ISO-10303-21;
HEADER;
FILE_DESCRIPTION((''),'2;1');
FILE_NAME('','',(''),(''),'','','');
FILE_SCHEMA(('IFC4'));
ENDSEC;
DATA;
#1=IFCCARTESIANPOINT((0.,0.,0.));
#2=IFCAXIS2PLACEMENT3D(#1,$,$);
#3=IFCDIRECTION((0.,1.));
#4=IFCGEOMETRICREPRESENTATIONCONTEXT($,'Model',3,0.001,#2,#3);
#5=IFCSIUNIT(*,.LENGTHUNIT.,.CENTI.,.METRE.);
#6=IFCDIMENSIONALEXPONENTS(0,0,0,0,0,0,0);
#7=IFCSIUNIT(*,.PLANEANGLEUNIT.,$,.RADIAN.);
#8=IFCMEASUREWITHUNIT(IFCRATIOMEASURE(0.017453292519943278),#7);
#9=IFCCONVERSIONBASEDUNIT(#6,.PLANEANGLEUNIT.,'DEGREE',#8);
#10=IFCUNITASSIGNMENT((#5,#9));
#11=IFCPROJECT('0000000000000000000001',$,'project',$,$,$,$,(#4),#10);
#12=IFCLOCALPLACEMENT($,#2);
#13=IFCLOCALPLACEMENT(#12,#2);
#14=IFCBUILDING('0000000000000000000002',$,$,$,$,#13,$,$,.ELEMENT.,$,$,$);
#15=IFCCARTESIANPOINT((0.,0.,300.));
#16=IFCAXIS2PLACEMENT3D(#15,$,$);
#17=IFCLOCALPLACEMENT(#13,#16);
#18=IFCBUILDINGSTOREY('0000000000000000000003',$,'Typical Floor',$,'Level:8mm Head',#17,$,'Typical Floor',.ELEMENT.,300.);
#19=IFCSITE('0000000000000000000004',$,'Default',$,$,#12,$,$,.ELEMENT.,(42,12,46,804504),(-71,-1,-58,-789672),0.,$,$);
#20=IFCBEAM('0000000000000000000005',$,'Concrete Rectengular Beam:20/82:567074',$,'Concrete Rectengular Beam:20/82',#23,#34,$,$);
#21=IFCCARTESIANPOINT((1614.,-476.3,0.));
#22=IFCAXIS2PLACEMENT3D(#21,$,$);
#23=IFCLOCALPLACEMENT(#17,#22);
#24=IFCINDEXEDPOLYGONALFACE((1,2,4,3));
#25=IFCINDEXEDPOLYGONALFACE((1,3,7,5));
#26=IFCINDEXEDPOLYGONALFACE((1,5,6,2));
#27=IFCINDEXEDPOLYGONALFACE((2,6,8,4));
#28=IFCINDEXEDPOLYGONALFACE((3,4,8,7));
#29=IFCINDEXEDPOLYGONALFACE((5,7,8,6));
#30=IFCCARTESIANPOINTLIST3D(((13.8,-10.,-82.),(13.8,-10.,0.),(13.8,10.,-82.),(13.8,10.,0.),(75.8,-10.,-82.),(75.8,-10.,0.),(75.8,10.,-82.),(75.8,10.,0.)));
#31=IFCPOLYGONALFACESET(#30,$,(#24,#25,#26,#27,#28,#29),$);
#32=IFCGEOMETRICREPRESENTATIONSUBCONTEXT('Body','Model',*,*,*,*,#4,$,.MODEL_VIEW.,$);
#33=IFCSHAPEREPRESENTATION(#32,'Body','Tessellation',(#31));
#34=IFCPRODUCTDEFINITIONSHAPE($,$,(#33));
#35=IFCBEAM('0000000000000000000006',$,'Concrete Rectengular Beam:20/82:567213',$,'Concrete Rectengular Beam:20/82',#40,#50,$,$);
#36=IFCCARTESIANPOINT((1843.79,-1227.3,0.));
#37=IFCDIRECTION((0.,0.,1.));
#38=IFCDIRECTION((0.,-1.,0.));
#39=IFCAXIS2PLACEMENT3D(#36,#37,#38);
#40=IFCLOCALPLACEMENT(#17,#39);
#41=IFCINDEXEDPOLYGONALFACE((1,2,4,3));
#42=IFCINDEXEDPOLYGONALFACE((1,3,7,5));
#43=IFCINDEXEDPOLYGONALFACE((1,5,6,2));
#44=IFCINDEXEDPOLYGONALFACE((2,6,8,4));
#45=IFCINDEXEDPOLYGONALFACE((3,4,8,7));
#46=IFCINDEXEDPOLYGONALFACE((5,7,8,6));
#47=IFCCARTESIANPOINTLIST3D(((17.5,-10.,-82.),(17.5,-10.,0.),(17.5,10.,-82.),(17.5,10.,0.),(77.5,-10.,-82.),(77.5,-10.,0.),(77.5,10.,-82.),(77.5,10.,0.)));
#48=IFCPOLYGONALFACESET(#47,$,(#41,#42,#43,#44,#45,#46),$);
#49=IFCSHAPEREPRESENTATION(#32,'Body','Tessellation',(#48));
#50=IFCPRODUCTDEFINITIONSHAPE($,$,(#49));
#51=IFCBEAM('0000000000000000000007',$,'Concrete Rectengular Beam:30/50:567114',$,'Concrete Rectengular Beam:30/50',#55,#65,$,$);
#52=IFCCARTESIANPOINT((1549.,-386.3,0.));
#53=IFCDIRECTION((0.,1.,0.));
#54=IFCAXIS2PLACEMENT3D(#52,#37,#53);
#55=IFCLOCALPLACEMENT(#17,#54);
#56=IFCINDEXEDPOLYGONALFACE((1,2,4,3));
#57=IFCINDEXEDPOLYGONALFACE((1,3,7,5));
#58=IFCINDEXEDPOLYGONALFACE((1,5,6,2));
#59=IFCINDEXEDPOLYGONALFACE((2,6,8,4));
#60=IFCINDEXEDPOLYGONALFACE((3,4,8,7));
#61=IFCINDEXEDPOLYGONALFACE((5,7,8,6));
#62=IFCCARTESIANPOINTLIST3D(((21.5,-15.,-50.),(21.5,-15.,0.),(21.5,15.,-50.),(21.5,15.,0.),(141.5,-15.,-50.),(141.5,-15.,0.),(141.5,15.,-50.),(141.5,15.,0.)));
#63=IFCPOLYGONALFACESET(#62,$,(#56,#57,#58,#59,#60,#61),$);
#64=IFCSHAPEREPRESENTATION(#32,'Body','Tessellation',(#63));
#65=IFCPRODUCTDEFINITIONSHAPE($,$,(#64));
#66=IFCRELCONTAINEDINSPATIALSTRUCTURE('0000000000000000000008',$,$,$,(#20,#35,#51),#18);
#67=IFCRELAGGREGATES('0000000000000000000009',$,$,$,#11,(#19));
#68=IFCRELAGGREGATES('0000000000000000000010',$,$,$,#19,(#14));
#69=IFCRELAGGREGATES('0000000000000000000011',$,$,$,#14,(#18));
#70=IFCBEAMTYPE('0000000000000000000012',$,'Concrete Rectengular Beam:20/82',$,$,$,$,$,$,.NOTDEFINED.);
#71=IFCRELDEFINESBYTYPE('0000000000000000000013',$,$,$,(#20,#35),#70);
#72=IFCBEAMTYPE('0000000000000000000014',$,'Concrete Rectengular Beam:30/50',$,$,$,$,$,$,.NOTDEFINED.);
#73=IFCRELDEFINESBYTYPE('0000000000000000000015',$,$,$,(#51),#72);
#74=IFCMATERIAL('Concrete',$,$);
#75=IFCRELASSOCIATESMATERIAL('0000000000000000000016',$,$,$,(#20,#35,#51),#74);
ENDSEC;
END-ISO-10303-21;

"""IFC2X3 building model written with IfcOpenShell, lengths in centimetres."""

from ifc_helpers import new_model, entity, si_unit, converted_unit, direction, frame, frame_2d, origin, origin_2d_with_axis, place, context, subcontext, project, spatial, rectangle, extrude, material, type_object, element, save


model = new_model("IFC2X3")

# Units and contexts
model_context = context("Model", 3, precision=0.001, world=origin(), true_north=direction((0.0, 1.0)))
body_context = subcontext(model_context, "Body", "Model", "MODEL_VIEW")
ifc_project = project(units=[si_unit("LENGTHUNIT", "METRE", prefix="CENTI"), converted_unit("PLANEANGLEUNIT", "DEGREE", entity("IfcRatioMeasure", 0.017453292519943278), si_unit("PLANEANGLEUNIT", "RADIAN"), dimensions=[0, 0, 0, 0, 0, 0, 0])], contexts=[model_context])

# Site, building, storey
site_placement = place(None, origin())
site = spatial("IfcSite", under=ifc_project, at=site_placement, Name="Default", CompositionType="ELEMENT", RefLatitude=(42, 12, 46, 804504), RefLongitude=(-71, -1, -58, -789672), RefElevation=0.0)
building_placement = place(site_placement, origin())
building = spatial("IfcBuilding", under=site, at=building_placement, CompositionType="ELEMENT")
storey_placement = place(building_placement, frame((0.0, 0.0, 300.0)))
storey = spatial("IfcBuildingStorey", under=building, at=storey_placement, Name="Typical Floor", ObjectType="Level:8mm Head", LongName="Typical Floor", CompositionType="ELEMENT", Elevation=300.0)

# Beams
ifc_material = material(Name="Concrete")
beam_type_1 = type_object("IfcBeamType", Name="Concrete Rectengular Beam:20/82", PredefinedType="NOTDEFINED")
beam_1_placement = place(storey_placement, frame((1614.0, -476.3, 0.0)))
element("IfcBeam", 1, at=beam_1_placement, inside=storey, type_object=beam_type_1, material=ifc_material, Name="Concrete Rectengular Beam:20/82:567074", ObjectType="Concrete Rectengular Beam:20/82", context=body_context, shape_type="SweptSolid", body=[
    extrude(rectangle(XDim=82.0, YDim=20.0, at=origin_2d_with_axis()), frame((13.8, 0.0, -41.0), z_axis=(1.0, 0.0, 0.0), x_axis=(0.0, 0.0, -1.0)), (0.0, 0.0, 1.0), 62.0),
])
beam_2_placement = place(storey_placement, frame((1843.79, -1227.3, 0.0), z_axis=(0.0, 0.0, 1.0), x_axis=(0.0, -1.0, 0.0)))
element("IfcBeam", 2, at=beam_2_placement, inside=storey, type_object=beam_type_1, material=ifc_material, Name="Concrete Rectengular Beam:20/82:567213", ObjectType="Concrete Rectengular Beam:20/82", context=body_context, shape_type="SweptSolid", body=[
    extrude(rectangle(XDim=82.0, YDim=20.0, at=frame_2d((0.0, 0.0), x_axis=(1.0, 0.0))), frame((17.5, 0.0, -41.0), z_axis=(1.0, 0.0, 0.0), x_axis=(0.0, 0.0, -1.0)), (0.0, 0.0, 1.0), 60.0),
])
beam_type_2 = type_object("IfcBeamType", Name="Concrete Rectengular Beam:30/50", PredefinedType="NOTDEFINED")
beam_3_placement = place(storey_placement, frame((1549.0, -386.3, 0.0), z_axis=(0.0, 0.0, 1.0), x_axis=(0.0, 1.0, 0.0)))
element("IfcBeam", 3, at=beam_3_placement, inside=storey, type_object=beam_type_2, material=ifc_material, Name="Concrete Rectengular Beam:30/50:567114", ObjectType="Concrete Rectengular Beam:30/50", context=body_context, shape_type="SweptSolid", body=[
    extrude(rectangle(XDim=50.0, YDim=30.0, at=frame_2d((0.0, 0.0), x_axis=(1.0, 0.0))), frame((21.5, 0.0, -25.0), z_axis=(1.0, 0.0, 0.0), x_axis=(0.0, 0.0, -1.0)), (0.0, 0.0, 1.0), 120.0),
])

save(model, "model.ifc")
